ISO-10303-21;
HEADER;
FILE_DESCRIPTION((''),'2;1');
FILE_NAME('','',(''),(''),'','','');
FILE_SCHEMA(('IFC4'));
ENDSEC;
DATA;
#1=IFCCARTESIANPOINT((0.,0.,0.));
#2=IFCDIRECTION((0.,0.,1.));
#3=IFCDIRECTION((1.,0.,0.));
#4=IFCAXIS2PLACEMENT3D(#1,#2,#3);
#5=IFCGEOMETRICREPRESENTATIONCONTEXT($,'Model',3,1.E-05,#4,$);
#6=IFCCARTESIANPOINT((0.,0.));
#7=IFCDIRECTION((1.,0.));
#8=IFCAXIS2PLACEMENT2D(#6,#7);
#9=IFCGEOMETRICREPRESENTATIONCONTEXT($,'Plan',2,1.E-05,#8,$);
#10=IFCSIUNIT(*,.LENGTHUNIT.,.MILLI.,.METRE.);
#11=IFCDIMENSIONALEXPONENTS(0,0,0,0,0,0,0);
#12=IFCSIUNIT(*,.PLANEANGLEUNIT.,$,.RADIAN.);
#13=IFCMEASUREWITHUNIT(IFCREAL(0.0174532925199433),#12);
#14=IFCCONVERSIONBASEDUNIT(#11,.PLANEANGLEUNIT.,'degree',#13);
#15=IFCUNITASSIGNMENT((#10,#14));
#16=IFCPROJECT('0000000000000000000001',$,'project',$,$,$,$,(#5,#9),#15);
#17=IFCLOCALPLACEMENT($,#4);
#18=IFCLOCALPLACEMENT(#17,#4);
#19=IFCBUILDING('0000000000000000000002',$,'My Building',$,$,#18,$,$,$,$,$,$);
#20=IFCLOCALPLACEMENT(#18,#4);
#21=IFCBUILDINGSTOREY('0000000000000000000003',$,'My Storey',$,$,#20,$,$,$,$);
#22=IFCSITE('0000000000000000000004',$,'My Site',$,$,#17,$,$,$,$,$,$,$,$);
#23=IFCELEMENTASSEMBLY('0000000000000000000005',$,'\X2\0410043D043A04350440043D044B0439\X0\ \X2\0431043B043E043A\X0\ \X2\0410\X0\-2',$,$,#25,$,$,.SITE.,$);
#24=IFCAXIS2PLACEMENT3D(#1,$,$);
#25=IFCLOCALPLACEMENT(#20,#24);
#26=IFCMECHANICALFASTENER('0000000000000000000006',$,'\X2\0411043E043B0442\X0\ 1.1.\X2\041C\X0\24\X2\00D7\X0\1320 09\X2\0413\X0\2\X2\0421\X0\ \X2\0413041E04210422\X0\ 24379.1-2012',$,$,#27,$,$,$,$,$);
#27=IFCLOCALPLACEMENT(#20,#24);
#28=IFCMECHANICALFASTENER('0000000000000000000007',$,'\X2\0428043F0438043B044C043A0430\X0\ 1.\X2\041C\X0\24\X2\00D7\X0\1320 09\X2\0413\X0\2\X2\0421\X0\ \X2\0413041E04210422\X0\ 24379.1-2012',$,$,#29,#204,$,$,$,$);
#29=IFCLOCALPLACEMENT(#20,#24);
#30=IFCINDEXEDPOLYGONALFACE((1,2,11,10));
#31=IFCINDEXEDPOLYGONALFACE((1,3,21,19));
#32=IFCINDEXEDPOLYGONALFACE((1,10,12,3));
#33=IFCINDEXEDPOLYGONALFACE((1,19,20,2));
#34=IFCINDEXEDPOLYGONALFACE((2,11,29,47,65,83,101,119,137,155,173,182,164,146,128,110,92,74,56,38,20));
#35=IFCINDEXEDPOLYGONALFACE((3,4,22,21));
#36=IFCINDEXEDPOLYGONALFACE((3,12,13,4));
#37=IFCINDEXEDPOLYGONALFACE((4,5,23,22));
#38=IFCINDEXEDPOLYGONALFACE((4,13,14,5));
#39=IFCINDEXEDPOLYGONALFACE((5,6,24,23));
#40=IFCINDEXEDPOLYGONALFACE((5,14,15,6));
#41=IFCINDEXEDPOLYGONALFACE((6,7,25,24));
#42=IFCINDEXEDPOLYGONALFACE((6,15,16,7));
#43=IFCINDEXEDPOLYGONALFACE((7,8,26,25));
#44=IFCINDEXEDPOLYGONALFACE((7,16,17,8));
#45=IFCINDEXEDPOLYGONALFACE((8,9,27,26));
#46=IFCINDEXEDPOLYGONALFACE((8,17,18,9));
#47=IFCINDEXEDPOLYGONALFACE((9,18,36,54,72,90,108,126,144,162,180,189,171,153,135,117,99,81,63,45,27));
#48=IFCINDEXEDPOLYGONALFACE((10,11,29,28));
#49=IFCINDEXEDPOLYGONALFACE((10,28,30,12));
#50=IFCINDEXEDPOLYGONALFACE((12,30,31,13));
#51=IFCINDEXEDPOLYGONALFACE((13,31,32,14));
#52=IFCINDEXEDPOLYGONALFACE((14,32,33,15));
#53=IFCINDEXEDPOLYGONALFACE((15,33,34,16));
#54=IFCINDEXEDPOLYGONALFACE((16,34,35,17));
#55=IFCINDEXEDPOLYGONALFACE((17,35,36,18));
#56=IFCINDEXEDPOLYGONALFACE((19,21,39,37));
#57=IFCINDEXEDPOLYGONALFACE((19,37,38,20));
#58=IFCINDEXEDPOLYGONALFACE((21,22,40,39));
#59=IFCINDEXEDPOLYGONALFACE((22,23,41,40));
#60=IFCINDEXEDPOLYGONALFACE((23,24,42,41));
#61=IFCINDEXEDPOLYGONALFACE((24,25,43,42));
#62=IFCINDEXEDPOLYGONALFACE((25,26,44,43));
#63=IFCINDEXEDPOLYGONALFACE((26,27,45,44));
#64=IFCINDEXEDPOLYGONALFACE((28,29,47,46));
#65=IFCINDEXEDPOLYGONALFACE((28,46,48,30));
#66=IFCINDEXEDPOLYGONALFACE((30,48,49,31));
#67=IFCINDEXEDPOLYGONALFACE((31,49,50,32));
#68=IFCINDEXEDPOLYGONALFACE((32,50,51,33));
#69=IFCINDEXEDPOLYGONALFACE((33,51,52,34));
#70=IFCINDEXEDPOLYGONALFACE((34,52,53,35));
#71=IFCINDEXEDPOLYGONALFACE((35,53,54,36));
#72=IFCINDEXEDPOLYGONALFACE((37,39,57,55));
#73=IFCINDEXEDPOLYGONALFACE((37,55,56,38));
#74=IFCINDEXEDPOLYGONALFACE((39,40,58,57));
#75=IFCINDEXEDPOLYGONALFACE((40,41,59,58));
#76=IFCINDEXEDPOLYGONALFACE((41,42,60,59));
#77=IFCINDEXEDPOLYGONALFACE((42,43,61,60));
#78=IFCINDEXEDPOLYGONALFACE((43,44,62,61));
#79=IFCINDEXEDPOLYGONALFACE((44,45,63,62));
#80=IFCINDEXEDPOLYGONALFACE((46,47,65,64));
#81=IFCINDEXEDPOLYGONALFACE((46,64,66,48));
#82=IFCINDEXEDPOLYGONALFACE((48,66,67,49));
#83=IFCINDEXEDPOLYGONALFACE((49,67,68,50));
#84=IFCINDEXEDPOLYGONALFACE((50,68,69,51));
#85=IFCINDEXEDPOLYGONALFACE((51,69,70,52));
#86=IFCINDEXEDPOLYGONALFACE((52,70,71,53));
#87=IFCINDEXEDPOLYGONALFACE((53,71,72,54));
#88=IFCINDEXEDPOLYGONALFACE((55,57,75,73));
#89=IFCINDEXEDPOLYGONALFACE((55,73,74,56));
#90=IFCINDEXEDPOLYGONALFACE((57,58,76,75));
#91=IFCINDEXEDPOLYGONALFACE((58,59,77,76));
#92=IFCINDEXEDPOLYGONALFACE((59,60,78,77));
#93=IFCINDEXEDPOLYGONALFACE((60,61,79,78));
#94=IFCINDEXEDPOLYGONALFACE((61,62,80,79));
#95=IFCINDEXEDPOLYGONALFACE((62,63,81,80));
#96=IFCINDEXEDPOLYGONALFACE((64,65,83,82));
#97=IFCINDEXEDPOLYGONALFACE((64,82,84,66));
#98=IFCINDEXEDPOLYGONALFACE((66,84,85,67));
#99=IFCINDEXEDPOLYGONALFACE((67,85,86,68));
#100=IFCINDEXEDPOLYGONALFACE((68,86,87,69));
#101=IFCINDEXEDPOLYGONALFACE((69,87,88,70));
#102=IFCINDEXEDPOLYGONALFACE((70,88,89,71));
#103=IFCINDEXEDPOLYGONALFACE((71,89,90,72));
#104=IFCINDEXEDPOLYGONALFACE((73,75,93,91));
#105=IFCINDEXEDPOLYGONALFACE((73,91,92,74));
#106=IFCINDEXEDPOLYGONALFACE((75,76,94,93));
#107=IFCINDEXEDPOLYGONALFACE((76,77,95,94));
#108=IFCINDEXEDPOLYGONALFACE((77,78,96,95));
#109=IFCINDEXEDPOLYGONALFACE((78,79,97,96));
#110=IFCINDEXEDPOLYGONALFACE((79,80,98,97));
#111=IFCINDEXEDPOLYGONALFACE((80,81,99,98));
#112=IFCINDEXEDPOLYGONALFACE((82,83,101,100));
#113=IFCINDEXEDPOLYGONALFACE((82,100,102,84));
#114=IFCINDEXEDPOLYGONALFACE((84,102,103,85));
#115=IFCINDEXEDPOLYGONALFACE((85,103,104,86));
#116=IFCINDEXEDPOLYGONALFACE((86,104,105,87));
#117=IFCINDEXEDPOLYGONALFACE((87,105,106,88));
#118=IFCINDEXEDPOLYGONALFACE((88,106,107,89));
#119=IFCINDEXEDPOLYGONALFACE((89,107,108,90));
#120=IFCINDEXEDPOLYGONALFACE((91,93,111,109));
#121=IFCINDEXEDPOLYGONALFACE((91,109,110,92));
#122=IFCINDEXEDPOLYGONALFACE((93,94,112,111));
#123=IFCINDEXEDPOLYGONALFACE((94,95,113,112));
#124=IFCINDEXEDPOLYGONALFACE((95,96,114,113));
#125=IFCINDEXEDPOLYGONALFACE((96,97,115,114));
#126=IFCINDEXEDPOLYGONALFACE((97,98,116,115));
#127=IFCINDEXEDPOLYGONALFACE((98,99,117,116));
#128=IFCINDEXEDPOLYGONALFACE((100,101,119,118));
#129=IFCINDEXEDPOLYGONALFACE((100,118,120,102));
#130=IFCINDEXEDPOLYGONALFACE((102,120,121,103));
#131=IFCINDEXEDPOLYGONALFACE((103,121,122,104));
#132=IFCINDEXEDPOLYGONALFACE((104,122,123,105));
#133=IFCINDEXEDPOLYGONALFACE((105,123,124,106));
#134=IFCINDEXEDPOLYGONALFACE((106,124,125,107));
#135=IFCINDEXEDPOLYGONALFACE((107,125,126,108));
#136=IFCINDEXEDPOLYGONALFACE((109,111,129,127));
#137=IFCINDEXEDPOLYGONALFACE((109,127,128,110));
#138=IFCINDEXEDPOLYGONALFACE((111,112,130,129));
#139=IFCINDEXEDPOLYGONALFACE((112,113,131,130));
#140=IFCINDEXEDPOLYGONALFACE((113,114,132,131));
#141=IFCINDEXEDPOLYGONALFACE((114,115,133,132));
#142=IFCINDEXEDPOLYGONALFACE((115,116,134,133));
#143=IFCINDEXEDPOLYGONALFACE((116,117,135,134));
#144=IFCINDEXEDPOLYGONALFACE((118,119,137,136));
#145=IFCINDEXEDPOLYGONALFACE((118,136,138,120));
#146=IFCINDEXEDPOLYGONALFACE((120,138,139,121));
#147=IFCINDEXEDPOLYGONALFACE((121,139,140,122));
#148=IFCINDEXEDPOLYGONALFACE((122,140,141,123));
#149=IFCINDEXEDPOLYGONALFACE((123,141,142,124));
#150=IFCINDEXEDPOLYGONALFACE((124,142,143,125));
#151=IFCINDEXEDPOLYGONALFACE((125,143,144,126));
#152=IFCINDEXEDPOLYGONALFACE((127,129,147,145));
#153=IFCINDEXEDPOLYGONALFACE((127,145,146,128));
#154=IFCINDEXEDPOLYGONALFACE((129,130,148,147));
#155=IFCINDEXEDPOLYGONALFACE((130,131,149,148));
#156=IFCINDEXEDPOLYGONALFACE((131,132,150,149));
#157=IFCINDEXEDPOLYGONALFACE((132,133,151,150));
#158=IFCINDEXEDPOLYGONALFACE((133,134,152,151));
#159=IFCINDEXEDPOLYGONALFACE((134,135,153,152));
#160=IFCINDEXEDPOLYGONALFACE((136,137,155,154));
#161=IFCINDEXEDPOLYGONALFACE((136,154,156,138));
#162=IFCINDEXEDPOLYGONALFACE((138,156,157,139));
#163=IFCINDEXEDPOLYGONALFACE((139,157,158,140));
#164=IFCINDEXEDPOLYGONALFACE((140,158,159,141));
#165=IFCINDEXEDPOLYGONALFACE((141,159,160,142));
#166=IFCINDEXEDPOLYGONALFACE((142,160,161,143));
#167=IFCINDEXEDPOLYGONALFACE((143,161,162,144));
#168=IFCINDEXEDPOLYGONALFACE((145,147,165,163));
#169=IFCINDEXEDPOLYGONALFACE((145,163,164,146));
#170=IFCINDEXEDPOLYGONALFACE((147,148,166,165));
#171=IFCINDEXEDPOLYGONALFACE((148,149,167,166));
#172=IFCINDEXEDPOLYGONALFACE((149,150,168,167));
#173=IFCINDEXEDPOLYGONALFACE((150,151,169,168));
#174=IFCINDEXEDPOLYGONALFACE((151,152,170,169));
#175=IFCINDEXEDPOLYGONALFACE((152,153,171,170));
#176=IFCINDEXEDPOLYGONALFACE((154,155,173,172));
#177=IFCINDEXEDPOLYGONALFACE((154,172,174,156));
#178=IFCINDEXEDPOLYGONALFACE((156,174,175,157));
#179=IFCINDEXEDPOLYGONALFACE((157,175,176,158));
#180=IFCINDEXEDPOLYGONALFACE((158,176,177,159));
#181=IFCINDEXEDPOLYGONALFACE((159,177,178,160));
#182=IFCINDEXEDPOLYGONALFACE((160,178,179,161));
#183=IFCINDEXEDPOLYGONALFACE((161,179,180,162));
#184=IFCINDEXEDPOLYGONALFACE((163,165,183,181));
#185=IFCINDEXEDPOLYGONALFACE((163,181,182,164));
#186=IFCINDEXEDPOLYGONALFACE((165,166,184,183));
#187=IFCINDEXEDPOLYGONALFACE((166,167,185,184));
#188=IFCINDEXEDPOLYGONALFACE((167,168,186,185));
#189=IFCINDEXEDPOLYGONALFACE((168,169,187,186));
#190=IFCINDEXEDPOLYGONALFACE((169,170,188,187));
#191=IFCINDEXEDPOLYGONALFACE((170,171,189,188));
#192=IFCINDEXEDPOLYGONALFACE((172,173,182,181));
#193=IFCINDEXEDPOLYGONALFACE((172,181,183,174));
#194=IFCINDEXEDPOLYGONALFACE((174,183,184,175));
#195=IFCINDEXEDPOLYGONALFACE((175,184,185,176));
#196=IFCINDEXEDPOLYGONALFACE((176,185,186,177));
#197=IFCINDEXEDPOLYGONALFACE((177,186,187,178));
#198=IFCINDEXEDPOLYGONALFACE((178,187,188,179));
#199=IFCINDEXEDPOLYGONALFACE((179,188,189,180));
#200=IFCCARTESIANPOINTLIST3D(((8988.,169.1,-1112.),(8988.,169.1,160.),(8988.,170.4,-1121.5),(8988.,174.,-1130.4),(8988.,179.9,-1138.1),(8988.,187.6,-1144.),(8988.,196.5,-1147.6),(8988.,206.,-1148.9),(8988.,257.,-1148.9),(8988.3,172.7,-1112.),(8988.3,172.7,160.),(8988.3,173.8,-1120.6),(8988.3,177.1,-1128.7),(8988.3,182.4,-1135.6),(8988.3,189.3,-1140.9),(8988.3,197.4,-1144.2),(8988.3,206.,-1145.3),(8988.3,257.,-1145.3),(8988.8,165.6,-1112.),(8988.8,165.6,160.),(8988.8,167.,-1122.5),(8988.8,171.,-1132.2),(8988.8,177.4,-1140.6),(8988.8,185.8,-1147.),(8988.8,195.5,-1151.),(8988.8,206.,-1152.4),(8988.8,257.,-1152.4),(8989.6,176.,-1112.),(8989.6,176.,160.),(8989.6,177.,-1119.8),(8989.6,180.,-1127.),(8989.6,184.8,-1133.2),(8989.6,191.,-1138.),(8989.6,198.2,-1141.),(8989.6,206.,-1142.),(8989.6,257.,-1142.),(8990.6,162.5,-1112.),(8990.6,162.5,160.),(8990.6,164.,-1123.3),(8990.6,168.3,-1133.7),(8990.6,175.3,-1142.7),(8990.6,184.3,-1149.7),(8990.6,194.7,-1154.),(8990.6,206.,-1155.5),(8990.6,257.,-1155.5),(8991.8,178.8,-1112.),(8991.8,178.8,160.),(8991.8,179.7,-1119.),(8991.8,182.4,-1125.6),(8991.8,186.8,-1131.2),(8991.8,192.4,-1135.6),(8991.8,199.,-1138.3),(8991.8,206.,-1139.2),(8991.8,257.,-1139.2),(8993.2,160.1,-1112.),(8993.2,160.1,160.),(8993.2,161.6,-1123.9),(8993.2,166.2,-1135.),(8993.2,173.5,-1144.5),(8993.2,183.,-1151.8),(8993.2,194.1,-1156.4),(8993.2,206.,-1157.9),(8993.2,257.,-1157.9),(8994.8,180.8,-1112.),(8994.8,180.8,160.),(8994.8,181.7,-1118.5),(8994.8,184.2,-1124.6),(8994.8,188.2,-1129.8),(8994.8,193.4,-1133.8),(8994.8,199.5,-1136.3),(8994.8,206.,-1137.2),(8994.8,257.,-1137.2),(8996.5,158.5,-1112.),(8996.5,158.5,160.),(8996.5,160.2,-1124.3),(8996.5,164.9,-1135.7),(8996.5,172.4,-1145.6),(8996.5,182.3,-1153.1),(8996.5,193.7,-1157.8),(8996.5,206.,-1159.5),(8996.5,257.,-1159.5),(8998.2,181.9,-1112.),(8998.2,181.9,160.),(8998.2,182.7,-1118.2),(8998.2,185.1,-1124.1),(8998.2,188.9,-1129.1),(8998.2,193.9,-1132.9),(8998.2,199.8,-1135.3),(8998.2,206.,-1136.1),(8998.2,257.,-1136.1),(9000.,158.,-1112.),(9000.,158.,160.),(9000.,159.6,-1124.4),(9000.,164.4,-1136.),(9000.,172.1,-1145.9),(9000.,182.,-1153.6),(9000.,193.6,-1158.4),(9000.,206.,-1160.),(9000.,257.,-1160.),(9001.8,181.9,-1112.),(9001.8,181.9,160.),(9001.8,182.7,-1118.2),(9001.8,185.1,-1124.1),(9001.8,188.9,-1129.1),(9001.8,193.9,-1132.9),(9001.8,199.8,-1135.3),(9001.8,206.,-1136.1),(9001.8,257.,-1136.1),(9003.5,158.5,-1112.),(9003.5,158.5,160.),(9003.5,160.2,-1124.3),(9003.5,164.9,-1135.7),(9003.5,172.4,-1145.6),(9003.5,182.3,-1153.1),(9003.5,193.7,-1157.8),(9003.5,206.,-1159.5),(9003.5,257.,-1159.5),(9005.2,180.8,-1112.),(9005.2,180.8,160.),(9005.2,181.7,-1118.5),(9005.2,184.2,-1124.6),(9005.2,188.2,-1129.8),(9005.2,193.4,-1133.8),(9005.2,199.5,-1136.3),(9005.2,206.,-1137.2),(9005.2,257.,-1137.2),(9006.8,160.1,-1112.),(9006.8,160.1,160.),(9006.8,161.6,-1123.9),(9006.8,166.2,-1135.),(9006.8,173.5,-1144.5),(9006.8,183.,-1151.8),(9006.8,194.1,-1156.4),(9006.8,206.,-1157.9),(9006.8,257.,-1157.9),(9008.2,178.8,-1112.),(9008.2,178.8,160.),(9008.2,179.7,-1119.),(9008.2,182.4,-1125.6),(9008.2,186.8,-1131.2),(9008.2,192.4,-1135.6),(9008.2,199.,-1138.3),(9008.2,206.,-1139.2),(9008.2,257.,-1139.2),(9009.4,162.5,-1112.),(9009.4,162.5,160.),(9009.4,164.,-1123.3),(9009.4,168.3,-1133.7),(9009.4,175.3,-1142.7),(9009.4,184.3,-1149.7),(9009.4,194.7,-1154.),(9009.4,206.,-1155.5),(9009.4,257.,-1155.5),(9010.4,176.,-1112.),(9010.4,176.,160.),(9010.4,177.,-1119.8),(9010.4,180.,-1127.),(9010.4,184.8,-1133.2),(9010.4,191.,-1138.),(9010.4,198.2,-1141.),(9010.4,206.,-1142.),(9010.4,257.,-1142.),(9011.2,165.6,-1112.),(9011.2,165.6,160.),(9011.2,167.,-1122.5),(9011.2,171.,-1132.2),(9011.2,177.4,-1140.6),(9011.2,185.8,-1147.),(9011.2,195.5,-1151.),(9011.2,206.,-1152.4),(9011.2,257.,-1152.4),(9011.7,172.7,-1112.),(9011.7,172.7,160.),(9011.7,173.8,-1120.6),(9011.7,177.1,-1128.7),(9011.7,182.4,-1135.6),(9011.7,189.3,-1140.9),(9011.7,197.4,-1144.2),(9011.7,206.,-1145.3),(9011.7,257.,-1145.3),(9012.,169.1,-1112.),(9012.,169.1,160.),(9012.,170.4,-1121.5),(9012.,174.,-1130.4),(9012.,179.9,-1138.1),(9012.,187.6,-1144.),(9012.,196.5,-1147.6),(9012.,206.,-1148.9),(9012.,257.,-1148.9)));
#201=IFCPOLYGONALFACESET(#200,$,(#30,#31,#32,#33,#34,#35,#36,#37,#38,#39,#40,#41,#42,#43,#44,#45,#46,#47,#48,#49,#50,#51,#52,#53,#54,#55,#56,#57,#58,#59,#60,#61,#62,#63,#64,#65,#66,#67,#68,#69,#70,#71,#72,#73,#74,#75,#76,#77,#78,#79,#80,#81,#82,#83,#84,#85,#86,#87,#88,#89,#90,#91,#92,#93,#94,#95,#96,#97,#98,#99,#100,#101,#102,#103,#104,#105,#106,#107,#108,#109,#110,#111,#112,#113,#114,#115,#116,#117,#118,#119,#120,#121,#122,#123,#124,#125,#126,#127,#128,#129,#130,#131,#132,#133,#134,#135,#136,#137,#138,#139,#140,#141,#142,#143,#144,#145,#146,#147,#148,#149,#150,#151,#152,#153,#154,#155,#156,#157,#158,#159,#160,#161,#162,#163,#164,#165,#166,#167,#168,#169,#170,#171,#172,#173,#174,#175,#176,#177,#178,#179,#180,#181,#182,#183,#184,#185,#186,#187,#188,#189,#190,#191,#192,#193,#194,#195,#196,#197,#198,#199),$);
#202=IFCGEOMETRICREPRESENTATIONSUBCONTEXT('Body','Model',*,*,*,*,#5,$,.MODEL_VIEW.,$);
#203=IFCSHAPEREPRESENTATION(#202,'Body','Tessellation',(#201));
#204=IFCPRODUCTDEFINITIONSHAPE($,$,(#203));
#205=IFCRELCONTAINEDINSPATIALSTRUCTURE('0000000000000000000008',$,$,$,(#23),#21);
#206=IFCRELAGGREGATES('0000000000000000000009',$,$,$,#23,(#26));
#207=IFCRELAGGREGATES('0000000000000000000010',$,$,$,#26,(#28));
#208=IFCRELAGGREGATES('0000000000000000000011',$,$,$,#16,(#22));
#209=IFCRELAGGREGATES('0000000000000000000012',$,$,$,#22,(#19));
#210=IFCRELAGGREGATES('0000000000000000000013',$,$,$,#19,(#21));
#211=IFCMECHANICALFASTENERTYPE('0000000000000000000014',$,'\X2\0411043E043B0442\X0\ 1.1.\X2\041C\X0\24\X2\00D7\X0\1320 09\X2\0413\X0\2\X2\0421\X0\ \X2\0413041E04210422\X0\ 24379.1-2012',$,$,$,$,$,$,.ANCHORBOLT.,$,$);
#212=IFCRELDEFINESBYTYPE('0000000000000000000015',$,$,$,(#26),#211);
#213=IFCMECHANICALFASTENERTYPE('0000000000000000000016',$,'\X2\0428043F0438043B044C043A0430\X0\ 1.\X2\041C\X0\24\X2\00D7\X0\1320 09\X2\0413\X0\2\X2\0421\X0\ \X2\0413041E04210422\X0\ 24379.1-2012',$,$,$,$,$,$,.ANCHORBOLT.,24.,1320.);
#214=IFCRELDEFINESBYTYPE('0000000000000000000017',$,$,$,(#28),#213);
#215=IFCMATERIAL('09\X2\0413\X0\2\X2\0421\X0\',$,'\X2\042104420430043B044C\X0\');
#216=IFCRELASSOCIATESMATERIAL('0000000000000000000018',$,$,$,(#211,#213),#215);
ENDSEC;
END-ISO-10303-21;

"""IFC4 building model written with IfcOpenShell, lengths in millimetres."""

from ifc_helpers import new_model, entity, si_unit, converted_unit, frame, origin_with_axes, origin_2d_with_axis, place, context, subcontext, project, spatial, source, transform, mapped, material, type_object, type_shapes, element, aggregate, save


model = new_model("IFC4")

# Units and contexts
model_context = context("Model", 3, precision=1e-05, world=origin_with_axes())
plan_context = context("Plan", 2, precision=1e-05, world=origin_2d_with_axis())
body_context = subcontext(model_context, "Body", "Model", "MODEL_VIEW")
ifc_project = project(units=[si_unit("LENGTHUNIT", "METRE", prefix="MILLI"), converted_unit("PLANEANGLEUNIT", "degree", entity("IfcReal", 0.0174532925199433), si_unit("PLANEANGLEUNIT", "RADIAN"), dimensions=[0, 0, 0, 0, 0, 0, 0])], contexts=[model_context, plan_context])

# Site, building, storey
site_placement = place(None, origin_with_axes())
site = spatial("IfcSite", under=ifc_project, at=site_placement, Name="My Site")
building_placement = place(site_placement, origin_with_axes())
building = spatial("IfcBuilding", under=site, at=building_placement, Name="My Building")
storey_placement = place(building_placement, origin_with_axes())
storey = spatial("IfcBuildingStorey", under=building, at=storey_placement, Name="My Storey")

# Element assembly, mechanical fasteners
ifc_material_1 = material(Name="09Г2С", Category="Сталь")
mechanical_fastener_type_1 = type_object("IfcMechanicalFastenerType", Name="Болт 1.1.М24×1320 09Г2С ГОСТ 24379.1-2012", PredefinedType="ANCHORBOLT", material=ifc_material_1)
mechanical_fastener_type_2 = type_object("IfcMechanicalFastenerType", Name="Шпилька 1.М24×1320 09Г2С ГОСТ 24379.1-2012", NominalDiameter=24.0, NominalLength=1320.0, PredefinedType="ANCHORBOLT", material=ifc_material_1)
shared_shape_1 = source(frame((0.0, 0.0, 110.0), z_axis=(0.0, 0.0, 1.0), x_axis=(1.0, 0.0, 0.0)), body_context, "Body", "AdvancedSweptSolid", [
    entity("IfcSweptDiskSolid", entity("IfcIndexedPolyCurve", entity("IfcCartesianPointList3D", [[0.0, 0.0, 0.0], [0.0, 0.0, -1272.0], [10.5, 0.0, -1297.5], [36.0, 0.0, -1308.0], [87.0, 0.0, -1308.0]]), [entity("IfcLineIndex", [1, 2]), entity("IfcArcIndex", [2, 3, 4]), entity("IfcLineIndex", [4, 5])]), 12.0),
])
type_shapes(mechanical_fastener_type_2, [shared_shape_1])
assembly_1_placement = place(storey_placement, frame((9000.0, 0.0, 0.0), z_axis=(0.0, 0.0, 1.0), x_axis=(1.0, 0.0, 0.0)))
assembly_1 = element("IfcElementAssembly", 1, at=assembly_1_placement, inside=storey, Name="Анкерный блок А-2", AssemblyPlace="SITE")
mechanical_fastener_1_placement = place(assembly_1_placement, frame((0.0, 170.0, 0.0), z_axis=(0.0, 0.0, 1.0), x_axis=(-1.0, 0.0, 0.0)))
mechanical_fastener_1 = element("IfcMechanicalFastener", 2, at=mechanical_fastener_1_placement, type_object=mechanical_fastener_type_1, Name="Болт 1.1.М24×1320 09Г2С ГОСТ 24379.1-2012")
aggregate(assembly_1, [mechanical_fastener_1])
mechanical_fastener_2_placement = place(mechanical_fastener_1_placement, frame((0.0, 0.0, 50.0), z_axis=(0.0, 0.0, 1.0), x_axis=(0.0, -1.0, 0.0)))
mechanical_fastener_2 = element("IfcMechanicalFastener", 3, at=mechanical_fastener_2_placement, type_object=mechanical_fastener_type_2, Name="Шпилька 1.М24×1320 09Г2С ГОСТ 24379.1-2012", context=body_context, shape_type="MappedRepresentation", body=[
    mapped(shared_shape_1, transform((0.0, 0.0, 0.0), x_axis=(1.0, 0.0, 0.0), y_axis=(0.0, 1.0, 0.0), z_axis=(0.0, 0.0, 1.0), scale=1.0)),
])

aggregate(mechanical_fastener_1, [mechanical_fastener_2])

save(model, "model.ifc")
